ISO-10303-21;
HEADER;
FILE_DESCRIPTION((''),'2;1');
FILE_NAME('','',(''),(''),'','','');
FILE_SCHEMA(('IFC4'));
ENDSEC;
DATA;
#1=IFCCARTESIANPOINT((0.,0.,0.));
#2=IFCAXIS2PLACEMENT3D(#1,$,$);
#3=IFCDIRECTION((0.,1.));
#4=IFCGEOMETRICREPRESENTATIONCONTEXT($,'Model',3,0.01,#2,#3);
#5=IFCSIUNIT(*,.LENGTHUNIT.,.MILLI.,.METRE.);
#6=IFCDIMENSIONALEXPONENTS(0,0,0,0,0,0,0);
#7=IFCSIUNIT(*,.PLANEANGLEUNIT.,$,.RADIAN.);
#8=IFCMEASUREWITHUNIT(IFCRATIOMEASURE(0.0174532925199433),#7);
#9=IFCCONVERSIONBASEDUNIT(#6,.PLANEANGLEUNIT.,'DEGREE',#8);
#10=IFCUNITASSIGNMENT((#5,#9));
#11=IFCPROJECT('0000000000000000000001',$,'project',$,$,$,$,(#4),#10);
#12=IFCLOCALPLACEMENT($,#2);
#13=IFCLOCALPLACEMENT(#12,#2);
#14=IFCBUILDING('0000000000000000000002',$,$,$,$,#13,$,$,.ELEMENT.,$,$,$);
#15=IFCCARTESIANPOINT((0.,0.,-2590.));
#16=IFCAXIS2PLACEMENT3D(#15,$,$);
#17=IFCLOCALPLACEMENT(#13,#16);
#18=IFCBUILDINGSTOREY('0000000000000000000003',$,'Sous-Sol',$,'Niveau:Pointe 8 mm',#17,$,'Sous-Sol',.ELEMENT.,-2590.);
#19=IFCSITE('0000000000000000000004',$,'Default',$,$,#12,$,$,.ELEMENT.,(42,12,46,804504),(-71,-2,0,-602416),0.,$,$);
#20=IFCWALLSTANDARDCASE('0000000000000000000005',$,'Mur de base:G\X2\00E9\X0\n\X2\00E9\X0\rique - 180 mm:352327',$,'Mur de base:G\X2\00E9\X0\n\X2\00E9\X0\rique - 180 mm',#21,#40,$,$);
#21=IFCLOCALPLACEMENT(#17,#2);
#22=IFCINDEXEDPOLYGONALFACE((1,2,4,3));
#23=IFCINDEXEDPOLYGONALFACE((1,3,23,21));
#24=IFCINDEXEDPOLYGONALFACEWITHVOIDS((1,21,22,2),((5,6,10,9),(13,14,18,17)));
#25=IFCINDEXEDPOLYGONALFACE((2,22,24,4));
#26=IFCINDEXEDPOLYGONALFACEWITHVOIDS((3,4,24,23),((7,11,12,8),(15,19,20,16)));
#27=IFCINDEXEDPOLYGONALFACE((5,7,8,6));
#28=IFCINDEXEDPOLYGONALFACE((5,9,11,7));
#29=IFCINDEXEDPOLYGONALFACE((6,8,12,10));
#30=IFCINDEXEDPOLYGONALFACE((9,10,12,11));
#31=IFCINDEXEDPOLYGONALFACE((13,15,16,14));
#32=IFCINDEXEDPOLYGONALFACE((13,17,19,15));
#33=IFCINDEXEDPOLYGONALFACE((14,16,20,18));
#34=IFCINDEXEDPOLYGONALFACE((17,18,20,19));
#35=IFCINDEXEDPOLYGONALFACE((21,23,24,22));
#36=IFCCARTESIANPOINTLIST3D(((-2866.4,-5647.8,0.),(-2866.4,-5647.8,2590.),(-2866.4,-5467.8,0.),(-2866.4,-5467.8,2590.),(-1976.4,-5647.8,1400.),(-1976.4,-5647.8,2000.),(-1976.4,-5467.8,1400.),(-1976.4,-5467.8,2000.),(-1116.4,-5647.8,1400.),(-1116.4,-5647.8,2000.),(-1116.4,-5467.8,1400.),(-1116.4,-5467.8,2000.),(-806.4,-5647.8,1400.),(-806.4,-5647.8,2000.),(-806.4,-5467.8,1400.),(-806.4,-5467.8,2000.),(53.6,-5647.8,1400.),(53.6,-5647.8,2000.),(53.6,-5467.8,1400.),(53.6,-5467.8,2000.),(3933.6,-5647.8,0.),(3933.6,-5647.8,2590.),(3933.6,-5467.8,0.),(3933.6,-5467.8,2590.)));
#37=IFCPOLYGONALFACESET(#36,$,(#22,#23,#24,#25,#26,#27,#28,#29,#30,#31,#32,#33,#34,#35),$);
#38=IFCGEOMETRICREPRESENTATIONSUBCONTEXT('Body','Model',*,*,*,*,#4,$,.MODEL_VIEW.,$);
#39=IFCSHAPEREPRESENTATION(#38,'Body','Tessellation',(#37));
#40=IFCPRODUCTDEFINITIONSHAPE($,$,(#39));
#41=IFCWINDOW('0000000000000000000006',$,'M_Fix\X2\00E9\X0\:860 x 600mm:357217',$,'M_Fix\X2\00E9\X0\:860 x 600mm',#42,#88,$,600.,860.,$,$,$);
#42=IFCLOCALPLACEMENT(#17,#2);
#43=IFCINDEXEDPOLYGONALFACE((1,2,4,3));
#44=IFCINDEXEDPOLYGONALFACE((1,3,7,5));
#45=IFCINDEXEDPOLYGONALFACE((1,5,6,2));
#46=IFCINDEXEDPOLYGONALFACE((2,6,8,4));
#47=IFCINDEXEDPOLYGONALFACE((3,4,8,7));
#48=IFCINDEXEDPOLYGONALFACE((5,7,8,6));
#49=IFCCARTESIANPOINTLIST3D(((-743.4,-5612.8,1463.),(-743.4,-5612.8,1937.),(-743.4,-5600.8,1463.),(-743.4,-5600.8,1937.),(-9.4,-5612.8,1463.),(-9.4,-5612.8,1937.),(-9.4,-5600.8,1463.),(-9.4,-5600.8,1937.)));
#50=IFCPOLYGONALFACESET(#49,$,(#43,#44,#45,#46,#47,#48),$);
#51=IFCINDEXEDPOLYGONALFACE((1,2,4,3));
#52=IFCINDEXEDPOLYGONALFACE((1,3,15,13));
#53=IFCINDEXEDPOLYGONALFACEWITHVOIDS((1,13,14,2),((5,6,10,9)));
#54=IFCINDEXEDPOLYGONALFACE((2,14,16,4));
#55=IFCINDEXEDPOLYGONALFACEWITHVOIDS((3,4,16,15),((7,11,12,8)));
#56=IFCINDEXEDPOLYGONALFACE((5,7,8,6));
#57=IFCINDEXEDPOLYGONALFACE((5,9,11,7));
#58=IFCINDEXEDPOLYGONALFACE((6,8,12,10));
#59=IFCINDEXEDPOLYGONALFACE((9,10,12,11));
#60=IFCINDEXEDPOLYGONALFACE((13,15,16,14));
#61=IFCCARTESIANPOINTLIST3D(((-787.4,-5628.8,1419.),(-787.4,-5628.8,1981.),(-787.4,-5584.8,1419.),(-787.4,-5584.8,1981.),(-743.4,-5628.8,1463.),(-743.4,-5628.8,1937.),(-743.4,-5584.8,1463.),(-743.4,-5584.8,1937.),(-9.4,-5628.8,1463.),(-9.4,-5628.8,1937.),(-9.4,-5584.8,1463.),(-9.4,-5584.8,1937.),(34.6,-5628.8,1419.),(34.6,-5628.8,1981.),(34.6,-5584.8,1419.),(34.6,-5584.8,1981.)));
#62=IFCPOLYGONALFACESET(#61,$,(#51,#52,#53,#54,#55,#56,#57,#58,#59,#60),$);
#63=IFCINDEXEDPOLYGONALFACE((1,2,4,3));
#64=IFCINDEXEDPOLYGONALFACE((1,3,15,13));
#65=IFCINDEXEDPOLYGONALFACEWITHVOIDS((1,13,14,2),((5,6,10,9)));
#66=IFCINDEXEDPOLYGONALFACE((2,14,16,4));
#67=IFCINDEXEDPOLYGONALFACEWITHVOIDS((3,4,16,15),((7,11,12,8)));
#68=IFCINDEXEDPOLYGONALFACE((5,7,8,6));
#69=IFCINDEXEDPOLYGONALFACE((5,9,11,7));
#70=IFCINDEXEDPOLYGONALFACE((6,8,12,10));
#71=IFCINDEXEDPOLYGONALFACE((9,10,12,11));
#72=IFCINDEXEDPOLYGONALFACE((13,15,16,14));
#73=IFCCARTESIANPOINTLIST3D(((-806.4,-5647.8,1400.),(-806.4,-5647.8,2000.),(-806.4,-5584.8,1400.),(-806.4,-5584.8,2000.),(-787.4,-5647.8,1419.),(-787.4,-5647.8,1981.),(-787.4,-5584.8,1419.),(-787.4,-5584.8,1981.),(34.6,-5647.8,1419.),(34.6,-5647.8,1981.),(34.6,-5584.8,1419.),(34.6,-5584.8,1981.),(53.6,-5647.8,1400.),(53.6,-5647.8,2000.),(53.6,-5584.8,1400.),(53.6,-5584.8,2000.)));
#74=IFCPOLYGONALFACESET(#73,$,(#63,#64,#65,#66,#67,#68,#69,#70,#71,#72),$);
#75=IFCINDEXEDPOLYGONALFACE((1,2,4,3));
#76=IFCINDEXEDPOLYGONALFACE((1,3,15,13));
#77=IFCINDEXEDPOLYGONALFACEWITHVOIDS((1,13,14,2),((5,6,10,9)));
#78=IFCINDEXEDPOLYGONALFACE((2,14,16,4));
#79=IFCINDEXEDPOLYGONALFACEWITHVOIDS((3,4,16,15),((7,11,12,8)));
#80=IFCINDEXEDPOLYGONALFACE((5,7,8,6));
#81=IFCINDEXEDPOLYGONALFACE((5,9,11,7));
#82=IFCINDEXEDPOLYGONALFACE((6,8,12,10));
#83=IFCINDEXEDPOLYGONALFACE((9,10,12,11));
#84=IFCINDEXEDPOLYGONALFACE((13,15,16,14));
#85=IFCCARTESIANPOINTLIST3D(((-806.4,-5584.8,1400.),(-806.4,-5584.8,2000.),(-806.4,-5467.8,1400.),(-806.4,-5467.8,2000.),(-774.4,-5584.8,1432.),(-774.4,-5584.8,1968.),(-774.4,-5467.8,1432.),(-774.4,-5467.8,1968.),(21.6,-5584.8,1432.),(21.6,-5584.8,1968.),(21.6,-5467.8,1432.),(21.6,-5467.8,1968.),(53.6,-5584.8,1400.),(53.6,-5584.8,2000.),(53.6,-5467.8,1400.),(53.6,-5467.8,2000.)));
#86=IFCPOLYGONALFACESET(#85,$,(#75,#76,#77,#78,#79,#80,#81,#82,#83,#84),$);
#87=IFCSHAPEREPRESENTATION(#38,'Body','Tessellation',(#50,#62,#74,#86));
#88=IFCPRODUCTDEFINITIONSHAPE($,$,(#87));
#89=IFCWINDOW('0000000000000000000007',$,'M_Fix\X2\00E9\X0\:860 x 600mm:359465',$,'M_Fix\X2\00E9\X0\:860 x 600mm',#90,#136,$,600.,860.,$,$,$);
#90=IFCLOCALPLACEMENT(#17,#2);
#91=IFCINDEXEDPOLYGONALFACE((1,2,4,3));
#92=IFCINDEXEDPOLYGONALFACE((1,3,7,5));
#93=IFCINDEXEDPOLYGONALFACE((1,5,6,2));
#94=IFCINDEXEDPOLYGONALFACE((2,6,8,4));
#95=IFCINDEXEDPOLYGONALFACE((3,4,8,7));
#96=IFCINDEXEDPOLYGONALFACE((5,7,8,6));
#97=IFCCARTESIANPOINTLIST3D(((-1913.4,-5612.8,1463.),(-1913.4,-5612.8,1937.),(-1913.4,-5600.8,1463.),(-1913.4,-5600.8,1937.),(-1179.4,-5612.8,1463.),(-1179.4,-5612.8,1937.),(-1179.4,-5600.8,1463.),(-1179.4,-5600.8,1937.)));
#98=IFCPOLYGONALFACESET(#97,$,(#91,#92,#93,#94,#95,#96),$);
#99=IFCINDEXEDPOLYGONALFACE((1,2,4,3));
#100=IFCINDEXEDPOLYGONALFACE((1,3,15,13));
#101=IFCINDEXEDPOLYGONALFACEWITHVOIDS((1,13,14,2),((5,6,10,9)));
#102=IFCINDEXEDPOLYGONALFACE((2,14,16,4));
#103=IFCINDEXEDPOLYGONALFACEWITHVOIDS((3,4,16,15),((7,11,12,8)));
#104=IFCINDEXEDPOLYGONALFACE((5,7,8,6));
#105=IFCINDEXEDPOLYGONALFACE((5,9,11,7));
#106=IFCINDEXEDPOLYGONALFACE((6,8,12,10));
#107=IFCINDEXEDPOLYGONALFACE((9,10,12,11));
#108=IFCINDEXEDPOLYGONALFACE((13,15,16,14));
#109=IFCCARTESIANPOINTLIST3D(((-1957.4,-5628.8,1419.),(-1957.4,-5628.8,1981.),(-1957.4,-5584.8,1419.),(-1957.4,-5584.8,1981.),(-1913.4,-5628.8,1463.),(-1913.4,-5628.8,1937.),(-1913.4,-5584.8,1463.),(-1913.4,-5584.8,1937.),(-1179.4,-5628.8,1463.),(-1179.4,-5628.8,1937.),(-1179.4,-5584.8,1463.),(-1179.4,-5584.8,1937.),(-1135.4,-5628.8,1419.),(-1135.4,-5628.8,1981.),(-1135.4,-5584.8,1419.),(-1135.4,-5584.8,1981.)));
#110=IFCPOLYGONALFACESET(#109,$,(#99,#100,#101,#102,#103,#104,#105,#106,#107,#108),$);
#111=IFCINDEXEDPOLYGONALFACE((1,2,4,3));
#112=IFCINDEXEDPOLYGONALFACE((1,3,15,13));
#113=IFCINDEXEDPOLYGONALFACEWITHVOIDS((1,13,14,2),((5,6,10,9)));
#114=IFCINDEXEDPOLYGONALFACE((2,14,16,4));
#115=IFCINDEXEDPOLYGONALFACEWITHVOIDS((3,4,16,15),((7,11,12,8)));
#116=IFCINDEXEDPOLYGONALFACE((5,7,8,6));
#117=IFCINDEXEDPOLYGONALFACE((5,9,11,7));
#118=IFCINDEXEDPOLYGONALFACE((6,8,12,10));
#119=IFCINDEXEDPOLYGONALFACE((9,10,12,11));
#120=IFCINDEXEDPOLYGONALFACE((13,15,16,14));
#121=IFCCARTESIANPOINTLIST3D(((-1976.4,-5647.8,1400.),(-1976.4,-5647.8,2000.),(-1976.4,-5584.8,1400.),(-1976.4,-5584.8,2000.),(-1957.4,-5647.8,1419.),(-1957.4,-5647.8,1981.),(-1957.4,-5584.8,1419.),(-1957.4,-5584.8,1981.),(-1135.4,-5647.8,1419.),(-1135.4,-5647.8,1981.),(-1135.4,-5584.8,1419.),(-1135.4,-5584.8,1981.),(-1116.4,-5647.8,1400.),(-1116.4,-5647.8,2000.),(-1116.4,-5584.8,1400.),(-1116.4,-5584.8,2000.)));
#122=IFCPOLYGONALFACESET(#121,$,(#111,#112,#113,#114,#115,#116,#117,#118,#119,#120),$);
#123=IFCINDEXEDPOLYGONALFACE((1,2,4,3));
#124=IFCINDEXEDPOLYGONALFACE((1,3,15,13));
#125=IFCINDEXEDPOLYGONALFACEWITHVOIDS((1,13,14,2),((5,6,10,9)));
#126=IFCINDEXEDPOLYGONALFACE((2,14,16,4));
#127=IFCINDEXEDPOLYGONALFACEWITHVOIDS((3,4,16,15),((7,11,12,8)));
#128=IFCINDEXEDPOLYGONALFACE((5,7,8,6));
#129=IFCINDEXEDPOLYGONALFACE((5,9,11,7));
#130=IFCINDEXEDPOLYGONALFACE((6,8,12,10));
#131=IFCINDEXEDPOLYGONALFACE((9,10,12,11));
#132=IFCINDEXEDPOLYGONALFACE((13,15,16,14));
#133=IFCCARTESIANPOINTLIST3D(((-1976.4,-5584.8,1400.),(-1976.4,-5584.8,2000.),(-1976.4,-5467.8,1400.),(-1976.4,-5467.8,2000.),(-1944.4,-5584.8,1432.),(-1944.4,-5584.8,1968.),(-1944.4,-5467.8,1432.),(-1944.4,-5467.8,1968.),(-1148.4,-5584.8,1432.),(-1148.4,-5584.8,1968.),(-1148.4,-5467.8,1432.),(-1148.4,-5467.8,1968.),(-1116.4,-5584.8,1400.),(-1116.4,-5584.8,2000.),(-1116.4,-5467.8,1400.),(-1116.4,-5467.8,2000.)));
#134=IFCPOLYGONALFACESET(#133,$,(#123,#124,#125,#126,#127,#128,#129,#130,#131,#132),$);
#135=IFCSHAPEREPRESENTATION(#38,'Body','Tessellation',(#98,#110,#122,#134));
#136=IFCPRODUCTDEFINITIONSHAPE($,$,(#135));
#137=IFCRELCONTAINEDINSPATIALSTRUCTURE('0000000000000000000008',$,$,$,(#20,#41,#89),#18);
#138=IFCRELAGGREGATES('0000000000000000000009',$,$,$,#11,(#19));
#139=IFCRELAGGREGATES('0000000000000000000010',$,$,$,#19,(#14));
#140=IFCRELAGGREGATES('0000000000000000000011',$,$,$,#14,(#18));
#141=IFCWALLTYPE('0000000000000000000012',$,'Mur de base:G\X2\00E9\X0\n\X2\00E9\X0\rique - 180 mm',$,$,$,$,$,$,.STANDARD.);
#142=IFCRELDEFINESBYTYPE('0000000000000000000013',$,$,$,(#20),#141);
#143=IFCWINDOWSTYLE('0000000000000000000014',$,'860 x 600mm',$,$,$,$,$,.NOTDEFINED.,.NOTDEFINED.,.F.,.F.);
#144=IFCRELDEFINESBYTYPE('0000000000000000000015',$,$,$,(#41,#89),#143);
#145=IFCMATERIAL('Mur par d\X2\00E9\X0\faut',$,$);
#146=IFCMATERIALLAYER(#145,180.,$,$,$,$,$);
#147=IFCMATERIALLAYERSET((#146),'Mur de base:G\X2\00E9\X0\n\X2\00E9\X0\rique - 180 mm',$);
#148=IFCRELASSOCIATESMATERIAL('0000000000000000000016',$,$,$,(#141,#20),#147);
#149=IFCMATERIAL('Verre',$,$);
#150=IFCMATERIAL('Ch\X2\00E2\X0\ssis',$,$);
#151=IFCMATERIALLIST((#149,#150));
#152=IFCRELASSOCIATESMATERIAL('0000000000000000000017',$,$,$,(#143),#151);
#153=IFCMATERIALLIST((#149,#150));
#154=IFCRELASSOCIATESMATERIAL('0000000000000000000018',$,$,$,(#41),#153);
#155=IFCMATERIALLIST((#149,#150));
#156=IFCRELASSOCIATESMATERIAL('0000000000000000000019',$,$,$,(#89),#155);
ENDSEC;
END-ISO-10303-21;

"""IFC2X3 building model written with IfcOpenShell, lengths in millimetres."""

from ifc_helpers import new_model, entity, si_unit, converted_unit, direction, frame, frame_2d, origin, place, context, subcontext, project, spatial, polyline, rectangle, outline, extrude, source, transform, mapped, material, material_list, layer, layer_set, layer_usage, type_object, type_shapes, element, fill, save


model = new_model("IFC2X3")

# Units and contexts
model_context = context("Model", 3, precision=0.01, world=origin(), true_north=direction((0.0, 1.0)))
body_context = subcontext(model_context, "Body", "Model", "MODEL_VIEW")
ifc_project = project(units=[si_unit("LENGTHUNIT", "METRE", prefix="MILLI"), converted_unit("PLANEANGLEUNIT", "DEGREE", entity("IfcRatioMeasure", 0.0174532925199433), si_unit("PLANEANGLEUNIT", "RADIAN"), dimensions=[0, 0, 0, 0, 0, 0, 0])], contexts=[model_context])

# Site, building, storey
site_placement = place(None, origin())
site = spatial("IfcSite", under=ifc_project, at=site_placement, Name="Default", CompositionType="ELEMENT", RefLatitude=(42, 12, 46, 804504), RefLongitude=(-71, -2, 0, -602416), RefElevation=0.0)
building_placement = place(site_placement, origin())
building = spatial("IfcBuilding", under=site, at=building_placement, CompositionType="ELEMENT")
storey_placement = place(building_placement, frame((0.0, 0.0, -2590.0)))
storey = spatial("IfcBuildingStorey", under=building, at=storey_placement, Name="Sous-Sol", ObjectType="Niveau:Pointe 8 mm", LongName="Sous-Sol", CompositionType="ELEMENT", Elevation=-2590.0)

# Wall, openings, windows
ifc_material_1 = material(Name="Mur par défaut")
ifc_layer_1 = layer(ifc_material_1, 180.0)
ifc_layer_set_1 = layer_set([ifc_layer_1], Name="Mur de base:Générique - 180 mm")
ifc_layer_usage_1 = layer_usage(ifc_layer_set_1, "AXIS2", "NEGATIVE", 90.0)
wall_type_1 = type_object("IfcWallType", Name="Mur de base:Générique - 180 mm", PredefinedType="STANDARD", material=ifc_layer_set_1)
wall_1_placement = place(storey_placement, frame((-2866.4, -5557.8, 0.0)))
wall_1 = element("IfcWallStandardCase", 1, at=wall_1_placement, inside=storey, type_object=wall_type_1, material=ifc_layer_usage_1, Name="Mur de base:Générique - 180 mm:352327", ObjectType="Mur de base:Générique - 180 mm", context=body_context, shape_type="SweptSolid", body=[
    extrude(rectangle(XDim=6800.0, YDim=180.0, at=frame_2d((3400.0, 0.0), x_axis=(-1.0, 0.0))), origin(), (0.0, 0.0, 1.0), 2590.0),
])
opening_1_placement = place(wall_1_placement, frame((2920.0, 90.0, 1400.0)))
opening_1 = element("IfcOpeningElement", 2, at=opening_1_placement, cuts=wall_1, ObjectType="Opening", context=body_context, shape_type="SweptSolid", body=[
    extrude(rectangle(XDim=600.0, YDim=860.0, at=frame_2d((300.0, 430.0), x_axis=(1.0, 0.0))), frame((0.0, 0.0, 0.0), z_axis=(0.0, -1.0, 0.0), x_axis=(0.0, 0.0, 1.0)), (0.0, 0.0, 1.0), 180.0),
])
opening_2_placement = place(wall_1_placement, frame((1750.0, 90.0, 1400.0)))
opening_2 = element("IfcOpeningElement", 3, at=opening_2_placement, cuts=wall_1, ObjectType="Opening", context=body_context, shape_type="SweptSolid", body=[
    extrude(rectangle(XDim=600.0, YDim=860.0, at=frame_2d((300.0, 430.0), x_axis=(1.0, 0.0))), frame((0.0, 0.0, 0.0), z_axis=(0.0, -1.0, 0.0), x_axis=(0.0, 0.0, 1.0)), (0.0, 0.0, 1.0), 180.0),
])
ifc_material_2 = material(Name="Verre")
ifc_material_3 = material(Name="Châssis")
ifc_material_list_1 = material_list([ifc_material_2, ifc_material_3])
ifc_material_list_2 = material_list([ifc_material_2, ifc_material_3])
window_style_1 = type_object("IfcWindowStyle", Name="860 x 600mm", ConstructionType="NOTDEFINED", OperationType="NOTDEFINED", ParameterTakesPrecedence=False, Sizeable=False, material=ifc_material_list_2)
shared_shape_1 = source(origin(), body_context, "Body", "SweptSolid", [
    extrude(rectangle(XDim=12.0, YDim=734.0, at=frame_2d((0.0, 0.0), x_axis=(1.0, 0.0))), frame((430.0, 139.0, 63.0), z_axis=(0.0, 0.0, 1.0), x_axis=(0.0, -1.0, 0.0)), (0.0, 0.0, 1.0), 474.0),
    extrude(outline(polyline([(-411.0, -281.0), (411.0, -281.0), (411.0, 281.0), (-411.0, 281.0), (-411.0, -281.0)]), holes=[polyline([(-367.0, -237.0), (-367.0, 237.0), (367.0, 237.0), (367.0, -237.0), (-367.0, -237.0)])]), frame((430.0, 117.0, 300.0), z_axis=(0.0, 1.0, 0.0), x_axis=(1.0, 0.0, 0.0)), (0.0, 0.0, 1.0), 44.0),
    extrude(outline(polyline([(-430.0, -300.0), (430.0, -300.0), (430.0, 300.0), (-430.0, 300.0), (-430.0, -300.0)]), holes=[polyline([(-411.0, -281.0), (-411.0, 281.0), (411.0, 281.0), (411.0, -281.0), (-411.0, -281.0)])]), frame((430.0, 117.0, 300.0), z_axis=(0.0, 1.0, 0.0), x_axis=(1.0, 0.0, 0.0)), (0.0, 0.0, 1.0), 63.0),
    extrude(outline(polyline([(-430.0, -300.0), (430.0, -300.0), (430.0, 300.0), (-430.0, 300.0), (-430.0, -300.0)]), holes=[polyline([(-398.0, -268.0), (-398.0, 268.0), (398.0, 268.0), (398.0, -268.0), (-398.0, -268.0)])]), frame((430.0, 0.0, 300.0), z_axis=(0.0, 1.0, 0.0), x_axis=(1.0, 0.0, 0.0)), (0.0, 0.0, 1.0), 117.0),
])
type_shapes(window_style_1, [shared_shape_1])
window_1_placement = place(opening_1_placement, frame((0.0, 0.0, 0.0), z_axis=(0.0, 0.0, 1.0), x_axis=(-1.0, 0.0, 0.0)))
window_1 = element("IfcWindow", 4, at=window_1_placement, inside=storey, type_object=window_style_1, material=ifc_material_list_1, Name="M_Fixé:860 x 600mm:357217", ObjectType="M_Fixé:860 x 600mm", OverallHeight=600.0, OverallWidth=860.0, context=body_context, shape_type="MappedRepresentation", body=[
    mapped(shared_shape_1, transform((0.0, 0.0, 0.0), scale=1.0)),
])
fill(opening_1, window_1)
ifc_material_list_3 = material_list([ifc_material_2, ifc_material_3])
window_2_placement = place(opening_2_placement, frame((0.0, 0.0, 0.0), z_axis=(0.0, 0.0, 1.0), x_axis=(-1.0, 0.0, 0.0)))
window_2 = element("IfcWindow", 5, at=window_2_placement, inside=storey, type_object=window_style_1, material=ifc_material_list_3, Name="M_Fixé:860 x 600mm:359465", ObjectType="M_Fixé:860 x 600mm", OverallHeight=600.0, OverallWidth=860.0, context=body_context, shape_type="MappedRepresentation", body=[
    mapped(shared_shape_1, transform((0.0, 0.0, 0.0), scale=1.0)),
])
fill(opening_2, window_2)

save(model, "model.ifc")
